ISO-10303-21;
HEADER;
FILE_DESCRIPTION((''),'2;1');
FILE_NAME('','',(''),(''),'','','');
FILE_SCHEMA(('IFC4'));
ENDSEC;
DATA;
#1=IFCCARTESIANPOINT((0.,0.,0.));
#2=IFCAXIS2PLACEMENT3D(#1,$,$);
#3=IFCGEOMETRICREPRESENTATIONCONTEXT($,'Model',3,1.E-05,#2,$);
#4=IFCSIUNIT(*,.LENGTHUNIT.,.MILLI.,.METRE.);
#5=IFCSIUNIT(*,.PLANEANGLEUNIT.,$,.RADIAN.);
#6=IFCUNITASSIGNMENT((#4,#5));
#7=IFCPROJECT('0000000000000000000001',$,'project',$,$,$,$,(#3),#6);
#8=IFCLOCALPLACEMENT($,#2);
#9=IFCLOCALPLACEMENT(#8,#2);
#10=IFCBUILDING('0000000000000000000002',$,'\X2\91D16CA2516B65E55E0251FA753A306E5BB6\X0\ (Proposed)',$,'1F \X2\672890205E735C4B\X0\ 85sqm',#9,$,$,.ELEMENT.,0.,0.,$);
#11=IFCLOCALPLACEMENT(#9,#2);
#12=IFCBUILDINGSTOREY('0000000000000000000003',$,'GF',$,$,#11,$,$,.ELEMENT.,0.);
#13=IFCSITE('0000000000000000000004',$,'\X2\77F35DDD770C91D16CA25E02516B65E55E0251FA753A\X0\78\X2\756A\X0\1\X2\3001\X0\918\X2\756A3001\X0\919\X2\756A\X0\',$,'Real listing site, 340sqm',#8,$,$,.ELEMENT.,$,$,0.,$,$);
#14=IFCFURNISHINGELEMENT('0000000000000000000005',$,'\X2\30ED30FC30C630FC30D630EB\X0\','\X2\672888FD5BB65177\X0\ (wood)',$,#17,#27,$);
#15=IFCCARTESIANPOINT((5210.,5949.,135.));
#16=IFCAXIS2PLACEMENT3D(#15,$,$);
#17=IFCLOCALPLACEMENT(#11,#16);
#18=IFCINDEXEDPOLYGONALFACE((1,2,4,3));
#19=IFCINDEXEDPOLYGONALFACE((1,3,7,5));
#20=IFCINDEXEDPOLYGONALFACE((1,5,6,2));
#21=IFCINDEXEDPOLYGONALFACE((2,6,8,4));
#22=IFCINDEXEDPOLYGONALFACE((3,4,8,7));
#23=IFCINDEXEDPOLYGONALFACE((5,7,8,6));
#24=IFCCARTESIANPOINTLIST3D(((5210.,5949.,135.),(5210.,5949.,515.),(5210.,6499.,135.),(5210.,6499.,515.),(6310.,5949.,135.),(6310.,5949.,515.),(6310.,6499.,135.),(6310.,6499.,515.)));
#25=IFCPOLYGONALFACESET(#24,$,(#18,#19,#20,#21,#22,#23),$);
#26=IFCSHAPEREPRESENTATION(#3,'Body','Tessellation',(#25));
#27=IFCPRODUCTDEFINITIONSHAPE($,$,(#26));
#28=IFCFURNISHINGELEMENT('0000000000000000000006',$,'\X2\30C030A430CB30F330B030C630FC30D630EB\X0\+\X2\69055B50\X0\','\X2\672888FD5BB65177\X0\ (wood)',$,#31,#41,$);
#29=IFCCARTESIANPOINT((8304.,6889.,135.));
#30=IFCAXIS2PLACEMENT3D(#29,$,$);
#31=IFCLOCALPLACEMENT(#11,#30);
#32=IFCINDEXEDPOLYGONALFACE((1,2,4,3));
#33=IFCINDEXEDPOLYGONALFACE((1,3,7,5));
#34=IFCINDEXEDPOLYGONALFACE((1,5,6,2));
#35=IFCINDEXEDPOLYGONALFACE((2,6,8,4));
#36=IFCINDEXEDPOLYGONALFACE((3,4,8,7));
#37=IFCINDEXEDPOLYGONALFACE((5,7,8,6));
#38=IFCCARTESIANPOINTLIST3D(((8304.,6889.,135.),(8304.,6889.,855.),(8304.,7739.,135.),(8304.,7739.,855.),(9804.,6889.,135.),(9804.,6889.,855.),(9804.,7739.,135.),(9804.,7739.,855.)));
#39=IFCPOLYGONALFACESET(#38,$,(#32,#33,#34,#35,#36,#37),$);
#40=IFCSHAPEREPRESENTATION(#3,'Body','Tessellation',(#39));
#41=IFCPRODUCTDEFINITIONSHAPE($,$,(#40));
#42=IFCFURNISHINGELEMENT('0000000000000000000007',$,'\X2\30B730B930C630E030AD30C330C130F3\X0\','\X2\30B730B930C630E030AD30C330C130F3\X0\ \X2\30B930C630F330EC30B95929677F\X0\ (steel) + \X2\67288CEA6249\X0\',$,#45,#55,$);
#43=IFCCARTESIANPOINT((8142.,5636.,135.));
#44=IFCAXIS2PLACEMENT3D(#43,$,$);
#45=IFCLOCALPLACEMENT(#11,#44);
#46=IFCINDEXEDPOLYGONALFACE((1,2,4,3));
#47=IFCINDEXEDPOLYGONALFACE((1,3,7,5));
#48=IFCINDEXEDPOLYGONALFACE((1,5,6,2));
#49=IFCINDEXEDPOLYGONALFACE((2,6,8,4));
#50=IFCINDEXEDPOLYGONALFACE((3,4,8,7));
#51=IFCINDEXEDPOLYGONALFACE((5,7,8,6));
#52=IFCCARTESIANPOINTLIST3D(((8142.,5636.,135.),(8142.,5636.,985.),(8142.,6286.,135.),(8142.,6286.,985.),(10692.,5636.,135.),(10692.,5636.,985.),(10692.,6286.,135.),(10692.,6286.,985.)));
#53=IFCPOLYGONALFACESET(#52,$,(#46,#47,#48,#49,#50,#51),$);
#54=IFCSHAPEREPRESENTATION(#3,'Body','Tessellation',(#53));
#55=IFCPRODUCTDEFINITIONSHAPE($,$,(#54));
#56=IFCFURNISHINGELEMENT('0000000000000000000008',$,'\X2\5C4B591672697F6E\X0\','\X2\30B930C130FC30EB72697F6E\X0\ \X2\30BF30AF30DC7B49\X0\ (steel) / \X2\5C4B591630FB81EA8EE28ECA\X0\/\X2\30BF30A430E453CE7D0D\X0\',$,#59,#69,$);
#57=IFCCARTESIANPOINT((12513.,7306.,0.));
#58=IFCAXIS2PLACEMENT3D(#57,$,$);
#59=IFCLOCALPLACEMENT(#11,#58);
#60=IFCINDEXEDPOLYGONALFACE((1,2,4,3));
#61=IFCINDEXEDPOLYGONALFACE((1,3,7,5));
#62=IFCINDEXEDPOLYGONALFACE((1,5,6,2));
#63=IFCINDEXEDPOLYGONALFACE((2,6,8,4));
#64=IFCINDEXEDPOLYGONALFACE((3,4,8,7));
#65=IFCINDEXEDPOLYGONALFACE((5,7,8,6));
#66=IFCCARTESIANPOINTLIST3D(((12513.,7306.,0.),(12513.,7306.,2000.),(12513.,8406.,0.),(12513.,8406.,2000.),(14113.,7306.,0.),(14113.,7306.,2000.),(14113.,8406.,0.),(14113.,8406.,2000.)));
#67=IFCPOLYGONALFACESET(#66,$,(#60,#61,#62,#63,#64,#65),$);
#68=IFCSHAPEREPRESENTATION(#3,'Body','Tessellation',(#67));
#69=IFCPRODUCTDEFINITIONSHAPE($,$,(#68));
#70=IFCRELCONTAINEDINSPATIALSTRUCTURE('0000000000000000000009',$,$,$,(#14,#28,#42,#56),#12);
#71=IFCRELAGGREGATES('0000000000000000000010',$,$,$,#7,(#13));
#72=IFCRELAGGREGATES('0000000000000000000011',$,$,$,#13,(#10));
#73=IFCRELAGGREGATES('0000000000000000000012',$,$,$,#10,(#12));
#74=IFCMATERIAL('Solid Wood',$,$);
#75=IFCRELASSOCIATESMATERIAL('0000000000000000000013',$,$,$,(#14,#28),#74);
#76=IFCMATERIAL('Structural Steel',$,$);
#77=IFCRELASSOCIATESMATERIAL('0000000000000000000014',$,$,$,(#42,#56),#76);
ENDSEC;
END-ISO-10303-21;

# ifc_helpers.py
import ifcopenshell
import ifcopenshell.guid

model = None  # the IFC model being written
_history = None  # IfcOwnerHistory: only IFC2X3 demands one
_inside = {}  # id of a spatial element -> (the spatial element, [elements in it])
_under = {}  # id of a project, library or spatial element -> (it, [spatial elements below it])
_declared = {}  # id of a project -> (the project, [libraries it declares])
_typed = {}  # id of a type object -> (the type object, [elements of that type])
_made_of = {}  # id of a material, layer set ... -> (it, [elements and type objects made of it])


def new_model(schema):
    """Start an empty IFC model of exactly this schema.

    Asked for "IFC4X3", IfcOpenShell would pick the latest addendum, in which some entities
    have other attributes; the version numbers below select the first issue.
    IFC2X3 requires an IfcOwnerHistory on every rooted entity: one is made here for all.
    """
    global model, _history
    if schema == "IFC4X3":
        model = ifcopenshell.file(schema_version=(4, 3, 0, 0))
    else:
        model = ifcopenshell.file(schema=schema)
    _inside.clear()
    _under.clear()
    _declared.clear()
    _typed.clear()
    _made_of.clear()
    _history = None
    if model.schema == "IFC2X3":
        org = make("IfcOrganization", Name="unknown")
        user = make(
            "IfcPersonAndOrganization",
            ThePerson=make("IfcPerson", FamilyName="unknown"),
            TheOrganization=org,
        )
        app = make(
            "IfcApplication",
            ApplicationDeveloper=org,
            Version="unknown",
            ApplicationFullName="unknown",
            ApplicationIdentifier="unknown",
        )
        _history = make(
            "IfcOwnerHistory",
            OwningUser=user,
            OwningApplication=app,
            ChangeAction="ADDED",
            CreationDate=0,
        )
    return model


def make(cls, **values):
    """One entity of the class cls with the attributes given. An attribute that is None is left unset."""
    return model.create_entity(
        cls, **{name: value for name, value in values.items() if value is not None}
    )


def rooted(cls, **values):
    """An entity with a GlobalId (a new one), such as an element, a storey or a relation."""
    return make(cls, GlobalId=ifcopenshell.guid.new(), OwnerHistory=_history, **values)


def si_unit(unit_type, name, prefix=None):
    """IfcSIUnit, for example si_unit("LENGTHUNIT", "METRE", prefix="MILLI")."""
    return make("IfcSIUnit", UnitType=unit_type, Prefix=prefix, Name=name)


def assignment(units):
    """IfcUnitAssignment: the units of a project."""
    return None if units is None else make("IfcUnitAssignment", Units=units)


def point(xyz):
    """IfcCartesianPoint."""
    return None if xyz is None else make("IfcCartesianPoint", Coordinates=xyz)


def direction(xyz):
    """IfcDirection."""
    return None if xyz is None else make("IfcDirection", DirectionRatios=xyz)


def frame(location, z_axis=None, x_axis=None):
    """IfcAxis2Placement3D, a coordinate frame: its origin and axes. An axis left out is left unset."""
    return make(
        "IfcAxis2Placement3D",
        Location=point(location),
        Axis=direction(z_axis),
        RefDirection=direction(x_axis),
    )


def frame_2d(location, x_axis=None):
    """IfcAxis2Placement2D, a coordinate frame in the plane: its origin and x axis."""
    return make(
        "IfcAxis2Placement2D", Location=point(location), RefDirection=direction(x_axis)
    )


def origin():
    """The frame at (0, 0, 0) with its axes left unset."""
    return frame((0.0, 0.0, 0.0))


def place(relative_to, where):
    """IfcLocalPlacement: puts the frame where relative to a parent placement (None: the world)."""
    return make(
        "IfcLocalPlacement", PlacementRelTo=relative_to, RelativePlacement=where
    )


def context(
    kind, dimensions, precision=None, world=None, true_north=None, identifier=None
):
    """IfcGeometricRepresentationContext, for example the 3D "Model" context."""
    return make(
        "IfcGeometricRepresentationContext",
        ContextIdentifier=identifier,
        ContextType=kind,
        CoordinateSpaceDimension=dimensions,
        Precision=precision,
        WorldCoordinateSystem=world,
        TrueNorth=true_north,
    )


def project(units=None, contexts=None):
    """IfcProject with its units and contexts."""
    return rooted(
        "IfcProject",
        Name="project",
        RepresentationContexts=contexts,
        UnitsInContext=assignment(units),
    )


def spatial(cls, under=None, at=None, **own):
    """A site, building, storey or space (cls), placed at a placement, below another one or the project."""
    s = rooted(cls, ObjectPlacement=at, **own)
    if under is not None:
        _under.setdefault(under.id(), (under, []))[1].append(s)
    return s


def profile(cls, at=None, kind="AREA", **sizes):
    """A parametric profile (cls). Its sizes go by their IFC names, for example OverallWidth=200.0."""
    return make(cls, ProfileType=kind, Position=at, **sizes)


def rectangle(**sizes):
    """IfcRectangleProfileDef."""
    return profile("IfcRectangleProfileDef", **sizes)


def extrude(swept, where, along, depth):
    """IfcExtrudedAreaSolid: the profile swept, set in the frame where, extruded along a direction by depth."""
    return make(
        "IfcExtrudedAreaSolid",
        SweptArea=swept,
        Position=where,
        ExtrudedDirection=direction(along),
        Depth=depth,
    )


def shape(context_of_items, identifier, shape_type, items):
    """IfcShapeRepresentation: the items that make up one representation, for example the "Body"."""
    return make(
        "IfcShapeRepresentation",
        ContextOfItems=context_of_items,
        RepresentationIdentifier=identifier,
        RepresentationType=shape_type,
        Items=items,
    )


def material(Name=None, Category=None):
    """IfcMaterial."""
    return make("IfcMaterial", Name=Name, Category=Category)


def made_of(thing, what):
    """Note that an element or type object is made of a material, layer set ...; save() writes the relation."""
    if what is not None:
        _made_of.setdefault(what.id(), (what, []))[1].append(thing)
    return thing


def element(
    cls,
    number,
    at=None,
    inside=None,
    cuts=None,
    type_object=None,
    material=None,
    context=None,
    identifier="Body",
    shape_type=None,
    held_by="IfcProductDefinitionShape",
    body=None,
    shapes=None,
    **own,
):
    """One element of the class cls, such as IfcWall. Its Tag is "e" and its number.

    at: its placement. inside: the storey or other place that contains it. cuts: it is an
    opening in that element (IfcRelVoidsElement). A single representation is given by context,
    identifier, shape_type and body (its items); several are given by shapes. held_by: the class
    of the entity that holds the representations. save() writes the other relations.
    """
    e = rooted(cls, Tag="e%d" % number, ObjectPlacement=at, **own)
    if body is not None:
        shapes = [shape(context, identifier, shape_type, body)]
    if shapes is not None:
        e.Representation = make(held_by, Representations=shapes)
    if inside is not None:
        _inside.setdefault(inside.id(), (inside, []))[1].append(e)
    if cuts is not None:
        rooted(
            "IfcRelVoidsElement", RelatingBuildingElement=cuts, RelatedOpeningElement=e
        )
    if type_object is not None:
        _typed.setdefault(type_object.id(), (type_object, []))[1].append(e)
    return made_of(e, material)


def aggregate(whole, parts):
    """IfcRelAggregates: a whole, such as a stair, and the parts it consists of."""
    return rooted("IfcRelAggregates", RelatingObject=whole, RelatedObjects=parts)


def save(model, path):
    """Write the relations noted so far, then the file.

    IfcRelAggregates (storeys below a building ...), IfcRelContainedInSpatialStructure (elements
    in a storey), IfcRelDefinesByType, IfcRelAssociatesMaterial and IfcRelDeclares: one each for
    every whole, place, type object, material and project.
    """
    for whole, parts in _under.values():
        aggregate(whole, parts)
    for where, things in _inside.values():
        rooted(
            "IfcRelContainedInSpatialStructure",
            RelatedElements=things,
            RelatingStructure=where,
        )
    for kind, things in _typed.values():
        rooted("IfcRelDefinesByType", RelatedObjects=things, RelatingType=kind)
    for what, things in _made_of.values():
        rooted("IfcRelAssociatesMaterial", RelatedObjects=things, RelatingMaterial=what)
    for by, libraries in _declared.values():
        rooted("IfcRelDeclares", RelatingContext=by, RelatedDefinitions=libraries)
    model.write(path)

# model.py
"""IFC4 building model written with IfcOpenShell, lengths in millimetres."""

from ifc_helpers import new_model, si_unit, frame, frame_2d, origin, place, context, project, spatial, rectangle, extrude, material, element, save


model = new_model("IFC4")

# Units and contexts
model_context = context("Model", 3, precision=1e-05, world=origin())
ifc_project = project(units=[si_unit("LENGTHUNIT", "METRE", prefix="MILLI"), si_unit("PLANEANGLEUNIT", "RADIAN")], contexts=[model_context])

# Site, building, storey
site_placement = place(None, origin())
site = spatial("IfcSite", under=ifc_project, at=site_placement, Name="石川県金沢市八日市出町78番1、918番、919番", ObjectType="Real listing site, 340sqm", CompositionType="ELEMENT", RefElevation=0.0)
building_placement = place(site_placement, origin())
building = spatial("IfcBuilding", under=site, at=building_placement, Name="金沢八日市出町の家 (Proposed)", ObjectType="1F 木造平屋 85sqm", CompositionType="ELEMENT", ElevationOfRefHeight=0.0, ElevationOfTerrain=0.0)
storey_placement = place(building_placement, origin())
storey = spatial("IfcBuildingStorey", under=building, at=storey_placement, Name="GF", CompositionType="ELEMENT", Elevation=0.0)

# Shared definitions
ifc_material_1 = material(Name="Solid Wood")

# Shared definitions
ifc_material_2 = material(Name="Structural Steel")

# Furnishing elements
furnishing_1_placement = place(storey_placement, frame((5210.0, 5949.0, 135.0)))
element("IfcFurnishingElement", 1, at=furnishing_1_placement, inside=storey, material=ifc_material_1, Name="ローテーブル", Description="木製家具 (wood)", context=model_context, shape_type="SweptSolid", body=[
    extrude(rectangle(XDim=1100.0, YDim=550.0, at=frame_2d((550.0, 275.0))), frame((5210.0, 5949.0, 135.0)), (0.0, 0.0, 1.0), 380.0),
])
furnishing_2_placement = place(storey_placement, frame((8304.0, 6889.0, 135.0)))
element("IfcFurnishingElement", 2, at=furnishing_2_placement, inside=storey, material=ifc_material_1, Name="ダイニングテーブル+椅子", Description="木製家具 (wood)", context=model_context, shape_type="SweptSolid", body=[
    extrude(rectangle(XDim=1500.0, YDim=850.0, at=frame_2d((750.0, 425.0))), frame((8304.0, 6889.0, 135.0)), (0.0, 0.0, 1.0), 720.0),
])
furnishing_3_placement = place(storey_placement, frame((8142.0, 5636.0, 135.0)))
element("IfcFurnishingElement", 3, at=furnishing_3_placement, inside=storey, material=ifc_material_2, Name="システムキッチン", Description="システムキッチン ステンレス天板 (steel) + 木質扉", context=model_context, shape_type="SweptSolid", body=[
    extrude(rectangle(XDim=2550.0, YDim=650.0, at=frame_2d((1275.0, 325.0))), frame((8142.0, 5636.0, 135.0)), (0.0, 0.0, 1.0), 850.0),
])
furnishing_4_placement = place(storey_placement, frame((12513.0, 7306.0, 0.0)))
element("IfcFurnishingElement", 4, at=furnishing_4_placement, inside=storey, material=ifc_material_2, Name="屋外物置", Description="スチール物置 タクボ等 (steel) / 屋外・自転車/タイヤ収納", context=model_context, shape_type="SweptSolid", body=[
    extrude(rectangle(XDim=1600.0, YDim=1100.0, at=frame_2d((800.0, 550.0))), frame((12513.0, 7306.0, 0.0)), (0.0, 0.0, 1.0), 2000.0),
])

save(model, "model.ifc")
